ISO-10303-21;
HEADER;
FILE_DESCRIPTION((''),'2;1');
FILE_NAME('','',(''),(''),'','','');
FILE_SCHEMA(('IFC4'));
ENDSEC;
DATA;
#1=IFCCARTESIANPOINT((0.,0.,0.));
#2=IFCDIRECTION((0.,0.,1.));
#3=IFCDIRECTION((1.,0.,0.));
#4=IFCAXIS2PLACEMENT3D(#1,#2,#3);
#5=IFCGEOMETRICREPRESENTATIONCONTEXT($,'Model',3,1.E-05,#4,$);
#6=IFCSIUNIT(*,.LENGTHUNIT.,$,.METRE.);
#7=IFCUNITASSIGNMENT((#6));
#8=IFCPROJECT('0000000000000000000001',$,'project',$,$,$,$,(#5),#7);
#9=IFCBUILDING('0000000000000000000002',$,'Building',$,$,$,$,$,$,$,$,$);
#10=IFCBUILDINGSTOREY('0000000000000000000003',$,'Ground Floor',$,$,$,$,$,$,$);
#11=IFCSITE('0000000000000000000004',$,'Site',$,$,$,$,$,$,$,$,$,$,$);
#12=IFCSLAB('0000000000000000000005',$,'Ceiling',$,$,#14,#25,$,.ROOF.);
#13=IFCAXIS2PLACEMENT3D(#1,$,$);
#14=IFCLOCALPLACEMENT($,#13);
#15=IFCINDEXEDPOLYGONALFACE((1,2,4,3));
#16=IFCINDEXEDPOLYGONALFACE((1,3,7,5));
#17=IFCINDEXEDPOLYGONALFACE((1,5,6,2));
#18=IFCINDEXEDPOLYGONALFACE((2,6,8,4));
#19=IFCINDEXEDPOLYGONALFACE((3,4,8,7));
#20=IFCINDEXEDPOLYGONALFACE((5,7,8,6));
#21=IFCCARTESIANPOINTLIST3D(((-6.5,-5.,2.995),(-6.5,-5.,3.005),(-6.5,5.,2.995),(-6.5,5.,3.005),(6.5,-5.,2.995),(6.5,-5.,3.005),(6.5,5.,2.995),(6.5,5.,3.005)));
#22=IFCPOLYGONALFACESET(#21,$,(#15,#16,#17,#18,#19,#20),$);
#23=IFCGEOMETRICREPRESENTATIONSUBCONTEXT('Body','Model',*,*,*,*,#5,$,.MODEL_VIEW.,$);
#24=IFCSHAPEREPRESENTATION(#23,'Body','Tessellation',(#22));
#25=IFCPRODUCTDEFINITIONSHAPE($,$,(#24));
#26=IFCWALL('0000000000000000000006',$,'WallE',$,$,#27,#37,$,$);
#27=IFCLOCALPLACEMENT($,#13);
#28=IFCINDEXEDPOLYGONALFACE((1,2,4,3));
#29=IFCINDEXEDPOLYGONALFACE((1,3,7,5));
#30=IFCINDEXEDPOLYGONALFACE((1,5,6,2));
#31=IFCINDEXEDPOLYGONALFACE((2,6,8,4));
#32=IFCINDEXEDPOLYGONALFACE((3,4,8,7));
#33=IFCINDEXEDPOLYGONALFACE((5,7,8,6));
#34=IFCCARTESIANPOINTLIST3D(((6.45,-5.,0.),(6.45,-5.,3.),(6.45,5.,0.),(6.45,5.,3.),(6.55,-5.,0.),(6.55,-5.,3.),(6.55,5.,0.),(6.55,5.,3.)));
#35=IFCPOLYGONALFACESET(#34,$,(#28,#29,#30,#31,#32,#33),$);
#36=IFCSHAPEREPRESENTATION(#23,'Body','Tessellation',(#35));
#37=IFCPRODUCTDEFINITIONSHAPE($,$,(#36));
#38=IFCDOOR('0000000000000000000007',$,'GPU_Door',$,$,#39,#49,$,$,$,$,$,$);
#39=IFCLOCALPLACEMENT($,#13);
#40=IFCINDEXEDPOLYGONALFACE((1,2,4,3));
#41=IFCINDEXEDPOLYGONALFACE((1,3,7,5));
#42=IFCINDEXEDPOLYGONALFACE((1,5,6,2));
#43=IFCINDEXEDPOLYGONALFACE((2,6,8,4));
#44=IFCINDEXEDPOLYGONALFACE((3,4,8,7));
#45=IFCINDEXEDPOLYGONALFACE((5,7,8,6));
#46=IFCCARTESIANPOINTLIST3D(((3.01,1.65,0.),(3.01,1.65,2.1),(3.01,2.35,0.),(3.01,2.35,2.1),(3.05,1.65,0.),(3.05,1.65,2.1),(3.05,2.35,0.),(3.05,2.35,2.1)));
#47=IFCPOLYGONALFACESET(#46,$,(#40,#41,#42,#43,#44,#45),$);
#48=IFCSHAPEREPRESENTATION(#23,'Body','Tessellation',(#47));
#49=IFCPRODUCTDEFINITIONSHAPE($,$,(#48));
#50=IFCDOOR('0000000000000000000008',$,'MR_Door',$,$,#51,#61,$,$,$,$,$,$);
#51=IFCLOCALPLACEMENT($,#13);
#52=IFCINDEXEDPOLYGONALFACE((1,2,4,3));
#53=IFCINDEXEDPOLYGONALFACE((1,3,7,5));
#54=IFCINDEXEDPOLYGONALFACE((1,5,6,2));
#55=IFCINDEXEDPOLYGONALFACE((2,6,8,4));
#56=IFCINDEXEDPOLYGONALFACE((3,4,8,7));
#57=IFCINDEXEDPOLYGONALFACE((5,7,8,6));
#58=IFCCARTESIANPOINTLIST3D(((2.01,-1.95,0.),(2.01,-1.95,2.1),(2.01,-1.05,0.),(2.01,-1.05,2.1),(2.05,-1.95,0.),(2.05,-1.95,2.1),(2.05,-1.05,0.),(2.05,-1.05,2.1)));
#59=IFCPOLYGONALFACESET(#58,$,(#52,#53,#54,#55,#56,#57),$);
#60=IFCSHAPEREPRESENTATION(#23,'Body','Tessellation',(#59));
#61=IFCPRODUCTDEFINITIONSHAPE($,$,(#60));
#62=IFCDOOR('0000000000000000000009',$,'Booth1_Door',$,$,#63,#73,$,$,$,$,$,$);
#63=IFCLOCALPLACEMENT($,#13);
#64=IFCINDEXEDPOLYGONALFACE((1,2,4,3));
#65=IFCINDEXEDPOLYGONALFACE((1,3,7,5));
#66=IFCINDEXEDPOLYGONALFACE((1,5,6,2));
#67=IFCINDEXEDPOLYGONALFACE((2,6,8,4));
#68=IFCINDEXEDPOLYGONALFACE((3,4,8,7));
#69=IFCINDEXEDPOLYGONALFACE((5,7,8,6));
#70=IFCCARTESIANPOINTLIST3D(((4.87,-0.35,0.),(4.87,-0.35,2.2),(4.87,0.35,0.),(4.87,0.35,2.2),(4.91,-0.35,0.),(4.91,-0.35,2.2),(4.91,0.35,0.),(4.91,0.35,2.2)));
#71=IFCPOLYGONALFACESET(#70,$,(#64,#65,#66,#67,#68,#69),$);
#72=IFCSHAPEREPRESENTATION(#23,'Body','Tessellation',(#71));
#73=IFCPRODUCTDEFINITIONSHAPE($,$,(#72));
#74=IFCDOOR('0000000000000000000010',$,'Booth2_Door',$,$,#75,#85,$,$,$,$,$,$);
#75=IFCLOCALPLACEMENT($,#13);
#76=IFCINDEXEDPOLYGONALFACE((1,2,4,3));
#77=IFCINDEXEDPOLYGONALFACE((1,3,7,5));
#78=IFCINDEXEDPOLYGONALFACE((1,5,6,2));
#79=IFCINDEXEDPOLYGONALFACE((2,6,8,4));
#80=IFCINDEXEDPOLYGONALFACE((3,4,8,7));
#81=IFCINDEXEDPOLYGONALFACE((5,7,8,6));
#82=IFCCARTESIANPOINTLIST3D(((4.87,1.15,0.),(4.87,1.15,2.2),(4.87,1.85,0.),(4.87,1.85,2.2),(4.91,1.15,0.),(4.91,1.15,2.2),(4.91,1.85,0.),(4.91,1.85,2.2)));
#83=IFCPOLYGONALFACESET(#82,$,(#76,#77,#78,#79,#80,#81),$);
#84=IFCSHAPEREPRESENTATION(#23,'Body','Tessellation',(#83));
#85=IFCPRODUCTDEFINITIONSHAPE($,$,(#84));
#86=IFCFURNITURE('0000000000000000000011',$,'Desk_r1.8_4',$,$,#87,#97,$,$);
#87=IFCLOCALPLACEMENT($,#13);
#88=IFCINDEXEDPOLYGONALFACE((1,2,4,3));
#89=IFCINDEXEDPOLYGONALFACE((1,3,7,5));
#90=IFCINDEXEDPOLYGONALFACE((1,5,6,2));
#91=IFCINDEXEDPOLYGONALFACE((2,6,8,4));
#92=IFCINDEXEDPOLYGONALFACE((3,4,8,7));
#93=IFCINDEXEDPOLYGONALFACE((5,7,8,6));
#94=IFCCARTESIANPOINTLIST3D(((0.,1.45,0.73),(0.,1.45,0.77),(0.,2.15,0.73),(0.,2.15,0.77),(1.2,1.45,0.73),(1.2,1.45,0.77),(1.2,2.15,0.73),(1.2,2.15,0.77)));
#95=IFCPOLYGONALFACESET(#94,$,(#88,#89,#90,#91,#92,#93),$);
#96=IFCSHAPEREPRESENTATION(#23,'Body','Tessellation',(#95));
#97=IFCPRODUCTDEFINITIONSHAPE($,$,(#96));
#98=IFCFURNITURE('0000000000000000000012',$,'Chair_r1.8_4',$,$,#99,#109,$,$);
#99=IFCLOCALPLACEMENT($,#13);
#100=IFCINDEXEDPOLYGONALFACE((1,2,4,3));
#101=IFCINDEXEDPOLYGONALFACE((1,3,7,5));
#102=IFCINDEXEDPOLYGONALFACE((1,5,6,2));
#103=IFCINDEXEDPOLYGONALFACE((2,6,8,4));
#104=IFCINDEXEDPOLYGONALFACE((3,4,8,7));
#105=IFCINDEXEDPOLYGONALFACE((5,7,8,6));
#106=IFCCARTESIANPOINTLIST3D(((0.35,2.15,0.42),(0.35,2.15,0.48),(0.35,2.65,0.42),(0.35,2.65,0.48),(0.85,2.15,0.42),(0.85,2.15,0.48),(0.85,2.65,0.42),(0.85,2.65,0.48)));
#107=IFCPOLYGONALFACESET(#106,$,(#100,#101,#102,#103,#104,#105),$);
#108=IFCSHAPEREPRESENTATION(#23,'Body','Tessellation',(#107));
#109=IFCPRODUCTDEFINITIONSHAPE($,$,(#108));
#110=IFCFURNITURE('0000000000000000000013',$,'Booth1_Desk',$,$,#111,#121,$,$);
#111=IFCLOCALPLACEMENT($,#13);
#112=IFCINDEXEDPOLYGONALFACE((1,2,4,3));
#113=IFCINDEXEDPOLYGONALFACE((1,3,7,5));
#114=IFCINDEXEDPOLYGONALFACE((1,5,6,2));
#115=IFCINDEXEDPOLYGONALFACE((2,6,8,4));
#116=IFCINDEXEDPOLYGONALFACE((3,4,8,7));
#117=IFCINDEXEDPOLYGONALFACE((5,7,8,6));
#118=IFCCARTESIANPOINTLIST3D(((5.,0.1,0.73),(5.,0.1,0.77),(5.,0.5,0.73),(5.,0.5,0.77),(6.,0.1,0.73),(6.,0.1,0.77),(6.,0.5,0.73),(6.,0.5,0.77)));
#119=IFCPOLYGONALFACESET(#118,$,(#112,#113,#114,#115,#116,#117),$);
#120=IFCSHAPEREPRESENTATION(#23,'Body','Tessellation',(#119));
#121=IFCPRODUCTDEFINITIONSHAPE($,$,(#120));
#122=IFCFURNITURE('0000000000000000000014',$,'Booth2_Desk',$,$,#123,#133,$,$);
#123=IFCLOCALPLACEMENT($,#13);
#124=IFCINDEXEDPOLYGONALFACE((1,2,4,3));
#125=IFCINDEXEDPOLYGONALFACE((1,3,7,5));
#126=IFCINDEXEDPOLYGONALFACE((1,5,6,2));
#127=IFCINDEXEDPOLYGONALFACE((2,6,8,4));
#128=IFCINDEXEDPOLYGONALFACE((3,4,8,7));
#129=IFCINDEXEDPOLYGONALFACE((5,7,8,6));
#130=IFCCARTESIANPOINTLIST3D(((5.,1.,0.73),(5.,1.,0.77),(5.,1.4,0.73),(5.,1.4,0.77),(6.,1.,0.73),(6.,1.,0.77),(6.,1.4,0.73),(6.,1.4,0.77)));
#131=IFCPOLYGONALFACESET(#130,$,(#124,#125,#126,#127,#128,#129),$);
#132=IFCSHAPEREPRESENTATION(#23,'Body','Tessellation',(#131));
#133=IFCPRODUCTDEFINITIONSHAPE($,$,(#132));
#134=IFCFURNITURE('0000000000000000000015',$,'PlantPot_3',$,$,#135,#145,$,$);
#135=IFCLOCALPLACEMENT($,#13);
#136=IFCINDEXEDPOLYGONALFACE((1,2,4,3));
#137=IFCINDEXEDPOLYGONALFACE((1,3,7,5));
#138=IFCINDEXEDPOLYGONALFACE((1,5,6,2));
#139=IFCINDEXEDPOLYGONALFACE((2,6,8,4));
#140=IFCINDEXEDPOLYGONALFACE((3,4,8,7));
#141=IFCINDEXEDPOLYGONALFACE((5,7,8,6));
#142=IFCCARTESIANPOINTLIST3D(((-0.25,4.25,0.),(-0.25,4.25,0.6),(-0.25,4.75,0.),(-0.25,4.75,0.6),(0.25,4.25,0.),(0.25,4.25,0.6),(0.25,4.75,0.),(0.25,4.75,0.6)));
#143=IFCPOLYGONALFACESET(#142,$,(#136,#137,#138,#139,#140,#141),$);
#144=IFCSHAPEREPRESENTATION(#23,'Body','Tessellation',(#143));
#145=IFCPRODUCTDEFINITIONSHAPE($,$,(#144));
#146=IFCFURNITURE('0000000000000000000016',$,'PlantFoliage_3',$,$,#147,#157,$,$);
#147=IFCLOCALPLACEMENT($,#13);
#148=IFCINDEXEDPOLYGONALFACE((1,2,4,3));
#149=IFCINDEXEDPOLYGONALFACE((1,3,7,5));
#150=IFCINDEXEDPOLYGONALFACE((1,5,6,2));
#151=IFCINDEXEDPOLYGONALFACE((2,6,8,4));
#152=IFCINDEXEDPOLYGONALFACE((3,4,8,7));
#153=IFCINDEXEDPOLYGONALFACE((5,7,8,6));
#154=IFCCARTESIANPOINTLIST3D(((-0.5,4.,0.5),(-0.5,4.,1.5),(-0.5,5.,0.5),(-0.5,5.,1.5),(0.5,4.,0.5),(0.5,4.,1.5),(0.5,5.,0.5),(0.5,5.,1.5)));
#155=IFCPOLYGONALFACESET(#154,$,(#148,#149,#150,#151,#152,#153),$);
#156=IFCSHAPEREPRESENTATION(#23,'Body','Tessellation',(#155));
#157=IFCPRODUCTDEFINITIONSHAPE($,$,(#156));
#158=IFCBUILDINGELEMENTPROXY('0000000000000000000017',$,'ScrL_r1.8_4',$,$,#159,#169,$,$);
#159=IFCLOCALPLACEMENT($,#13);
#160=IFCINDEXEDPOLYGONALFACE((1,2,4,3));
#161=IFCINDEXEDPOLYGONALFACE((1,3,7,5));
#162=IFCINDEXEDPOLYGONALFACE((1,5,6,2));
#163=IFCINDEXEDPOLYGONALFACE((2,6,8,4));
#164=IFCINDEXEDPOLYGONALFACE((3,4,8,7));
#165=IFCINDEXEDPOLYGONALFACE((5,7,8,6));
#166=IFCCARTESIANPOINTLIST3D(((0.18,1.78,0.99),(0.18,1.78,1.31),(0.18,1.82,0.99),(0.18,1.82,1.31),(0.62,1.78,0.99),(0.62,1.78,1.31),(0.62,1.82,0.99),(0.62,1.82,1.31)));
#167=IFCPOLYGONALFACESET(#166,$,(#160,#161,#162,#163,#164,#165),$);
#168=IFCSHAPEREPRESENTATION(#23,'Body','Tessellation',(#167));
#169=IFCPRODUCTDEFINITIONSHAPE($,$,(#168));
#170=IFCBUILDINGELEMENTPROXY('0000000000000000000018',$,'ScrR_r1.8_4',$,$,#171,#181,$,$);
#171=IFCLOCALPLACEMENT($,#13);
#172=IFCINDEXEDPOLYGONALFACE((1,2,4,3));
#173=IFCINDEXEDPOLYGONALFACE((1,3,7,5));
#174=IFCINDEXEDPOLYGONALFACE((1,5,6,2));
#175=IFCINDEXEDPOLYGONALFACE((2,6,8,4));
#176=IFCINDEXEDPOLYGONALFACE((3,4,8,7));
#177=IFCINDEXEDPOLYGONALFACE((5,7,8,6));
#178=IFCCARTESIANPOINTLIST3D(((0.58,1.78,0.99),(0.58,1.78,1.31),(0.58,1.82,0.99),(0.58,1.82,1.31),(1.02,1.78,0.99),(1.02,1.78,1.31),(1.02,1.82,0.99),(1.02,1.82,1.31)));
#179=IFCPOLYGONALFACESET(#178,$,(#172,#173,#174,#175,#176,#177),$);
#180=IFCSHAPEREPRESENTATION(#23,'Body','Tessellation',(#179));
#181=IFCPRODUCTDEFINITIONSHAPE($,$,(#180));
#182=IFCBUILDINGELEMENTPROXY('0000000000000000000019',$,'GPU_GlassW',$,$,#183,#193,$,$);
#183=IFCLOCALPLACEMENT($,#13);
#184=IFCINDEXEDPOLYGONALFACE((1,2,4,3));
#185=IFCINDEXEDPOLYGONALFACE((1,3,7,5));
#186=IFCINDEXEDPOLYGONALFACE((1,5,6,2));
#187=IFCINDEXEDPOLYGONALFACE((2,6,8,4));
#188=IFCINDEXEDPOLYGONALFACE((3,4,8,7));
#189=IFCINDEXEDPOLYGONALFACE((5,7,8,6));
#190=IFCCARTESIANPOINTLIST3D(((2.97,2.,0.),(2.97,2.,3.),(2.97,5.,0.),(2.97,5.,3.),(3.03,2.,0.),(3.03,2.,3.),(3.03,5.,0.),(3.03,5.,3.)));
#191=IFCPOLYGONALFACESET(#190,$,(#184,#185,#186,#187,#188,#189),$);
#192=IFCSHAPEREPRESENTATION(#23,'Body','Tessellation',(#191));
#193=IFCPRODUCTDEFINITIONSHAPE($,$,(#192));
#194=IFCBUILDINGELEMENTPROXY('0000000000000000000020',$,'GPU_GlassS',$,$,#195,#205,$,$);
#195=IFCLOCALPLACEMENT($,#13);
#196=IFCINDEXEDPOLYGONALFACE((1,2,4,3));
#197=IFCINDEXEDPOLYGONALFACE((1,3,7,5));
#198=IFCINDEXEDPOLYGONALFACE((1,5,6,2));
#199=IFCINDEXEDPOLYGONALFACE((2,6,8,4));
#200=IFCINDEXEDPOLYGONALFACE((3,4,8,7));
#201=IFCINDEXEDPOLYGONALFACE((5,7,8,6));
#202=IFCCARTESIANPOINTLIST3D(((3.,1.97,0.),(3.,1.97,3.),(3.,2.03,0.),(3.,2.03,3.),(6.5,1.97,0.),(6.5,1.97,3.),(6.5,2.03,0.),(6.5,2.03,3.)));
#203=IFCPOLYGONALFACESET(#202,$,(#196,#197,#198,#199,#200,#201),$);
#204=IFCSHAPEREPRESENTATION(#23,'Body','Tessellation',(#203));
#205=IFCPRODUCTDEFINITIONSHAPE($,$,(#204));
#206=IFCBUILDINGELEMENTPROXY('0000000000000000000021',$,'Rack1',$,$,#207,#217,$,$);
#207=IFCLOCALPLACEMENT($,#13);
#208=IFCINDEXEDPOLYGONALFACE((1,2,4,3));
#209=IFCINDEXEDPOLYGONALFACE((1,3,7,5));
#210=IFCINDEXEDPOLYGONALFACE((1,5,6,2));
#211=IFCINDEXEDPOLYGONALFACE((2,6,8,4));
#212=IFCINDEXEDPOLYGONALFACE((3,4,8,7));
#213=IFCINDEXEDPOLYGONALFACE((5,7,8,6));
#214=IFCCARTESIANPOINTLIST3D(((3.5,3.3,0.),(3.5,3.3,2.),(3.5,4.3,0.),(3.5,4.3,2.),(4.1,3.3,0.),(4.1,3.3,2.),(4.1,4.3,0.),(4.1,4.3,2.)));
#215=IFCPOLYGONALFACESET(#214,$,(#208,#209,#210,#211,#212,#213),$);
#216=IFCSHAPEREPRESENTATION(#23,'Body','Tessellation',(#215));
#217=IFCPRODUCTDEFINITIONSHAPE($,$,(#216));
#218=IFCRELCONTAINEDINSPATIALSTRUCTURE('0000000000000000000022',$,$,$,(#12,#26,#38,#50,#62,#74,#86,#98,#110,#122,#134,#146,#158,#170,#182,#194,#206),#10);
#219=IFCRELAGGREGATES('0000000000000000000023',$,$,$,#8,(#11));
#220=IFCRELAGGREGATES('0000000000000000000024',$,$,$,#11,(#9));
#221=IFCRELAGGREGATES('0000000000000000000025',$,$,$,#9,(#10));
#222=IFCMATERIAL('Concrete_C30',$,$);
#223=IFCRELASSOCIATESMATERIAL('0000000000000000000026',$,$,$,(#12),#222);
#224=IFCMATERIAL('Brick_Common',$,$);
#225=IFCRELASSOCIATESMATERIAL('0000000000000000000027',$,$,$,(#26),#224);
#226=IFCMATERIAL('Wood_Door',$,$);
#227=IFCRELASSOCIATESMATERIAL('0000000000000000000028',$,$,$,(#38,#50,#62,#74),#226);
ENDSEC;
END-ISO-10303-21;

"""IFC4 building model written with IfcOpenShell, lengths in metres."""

from ifc_helpers import new_model, si_unit, frame, origin_with_axes, origin_2d, place, context, subcontext, project, spatial, rectangle, extrude, material, element, save


model = new_model("IFC4")

# Units and contexts
model_context = context("Model", 3, precision=1e-05, world=origin_with_axes())
body_context = subcontext(model_context, "Body", "Model", "MODEL_VIEW")
ifc_project = project(units=[si_unit("LENGTHUNIT", "METRE")], contexts=[model_context])

# Site, building, storey
site = spatial("IfcSite", under=ifc_project, Name="Site")
building = spatial("IfcBuilding", under=site, Name="Building")
storey = spatial("IfcBuildingStorey", under=building, Name="Ground Floor")

# Slab
ifc_material_1 = material(Name="Concrete_C30")
slab_placement = place(None, frame((0.0, 0.0, 3.0), z_axis=(0.0, 0.0, 1.0), x_axis=(1.0, 0.0, 0.0)))
element("IfcSlab", 1, at=slab_placement, inside=storey, material=ifc_material_1, Name="Ceiling", PredefinedType="ROOF", context=body_context, shape_type="SweptSolid", body=[
    extrude(rectangle(XDim=13.0, YDim=10.0, at=origin_2d()), frame((0.0, 0.0, -0.005)), (0.0, 0.0, 1.0), 0.01),
])

# Wall
ifc_material_2 = material(Name="Brick_Common")
wall_placement = place(None, frame((6.5, 0.0, 1.5), z_axis=(0.0, 0.0, 1.0), x_axis=(1.0, 0.0, 0.0)))
element("IfcWall", 2, at=wall_placement, inside=storey, material=ifc_material_2, Name="WallE", context=body_context, shape_type="SweptSolid", body=[
    extrude(rectangle(XDim=0.1, YDim=10.0, at=origin_2d()), frame((0.0, 0.0, -1.5)), (0.0, 0.0, 1.0), 3.0),
])

# Doors
ifc_material_3 = material(Name="Wood_Door")
door_1_placement = place(None, frame((3.03, 2.0, 1.05), z_axis=(0.0, 0.0, 1.0), x_axis=(1.0, 0.0, 0.0)))
element("IfcDoor", 3, at=door_1_placement, inside=storey, material=ifc_material_3, Name="GPU_Door", context=body_context, shape_type="SweptSolid", body=[
    extrude(rectangle(XDim=0.04, YDim=0.7, at=origin_2d()), frame((0.0, 0.0, -1.05)), (0.0, 0.0, 1.0), 2.1),
])
door_2_placement = place(None, frame((2.03, -1.5, 1.05), z_axis=(0.0, 0.0, 1.0), x_axis=(1.0, 0.0, 0.0)))
element("IfcDoor", 4, at=door_2_placement, inside=storey, material=ifc_material_3, Name="MR_Door", context=body_context, shape_type="SweptSolid", body=[
    extrude(rectangle(XDim=0.04, YDim=0.9, at=origin_2d()), frame((0.0, 0.0, -1.05)), (0.0, 0.0, 1.0), 2.1),
])
for number, where, z_axis, x_axis, name in (
    (5, (4.89, 0.0, 1.1), (0.0, 0.0, 1.0), (1.0, 0.0, 0.0), "Booth1_Door"),
    (6, (4.89, 1.5, 1.1), (0.0, 0.0, 1.0), (1.0, 0.0, 0.0), "Booth2_Door"),
):
    element("IfcDoor", number, at=place(None, frame(where, z_axis=z_axis, x_axis=x_axis)), inside=storey, material=ifc_material_3, Name=name, context=body_context, shape_type="SweptSolid", body=[
        extrude(rectangle(XDim=0.04, YDim=0.7, at=origin_2d()), frame((0.0, 0.0, -1.1)), (0.0, 0.0, 1.0), 2.2),
    ])

# Furniture
furniture_1_placement = place(None, frame((0.6, 1.8, 0.75), z_axis=(0.0, 0.0, 1.0), x_axis=(1.0, 0.0, 0.0)))
element("IfcFurniture", 7, at=furniture_1_placement, inside=storey, Name="Desk_r1.8_4", context=body_context, shape_type="SweptSolid", body=[
    extrude(rectangle(XDim=1.2, YDim=0.7, at=origin_2d()), frame((0.0, 0.0, -0.02)), (0.0, 0.0, 1.0), 0.04),
])
furniture_2_placement = place(None, frame((0.6, 2.4, 0.45), z_axis=(0.0, 0.0, 1.0), x_axis=(1.0, 0.0, 0.0)))
element("IfcFurniture", 8, at=furniture_2_placement, inside=storey, Name="Chair_r1.8_4", context=body_context, shape_type="SweptSolid", body=[
    extrude(rectangle(XDim=0.5, YDim=0.5, at=origin_2d()), frame((0.0, 0.0, -0.03)), (0.0, 0.0, 1.0), 0.06),
])
for number, where, z_axis, x_axis, name in (
    (9, (5.5, 0.3, 0.75), (0.0, 0.0, 1.0), (1.0, 0.0, 0.0), "Booth1_Desk"),
    (10, (5.5, 1.2, 0.75), (0.0, 0.0, 1.0), (1.0, 0.0, 0.0), "Booth2_Desk"),
):
    element("IfcFurniture", number, at=place(None, frame(where, z_axis=z_axis, x_axis=x_axis)), inside=storey, Name=name, context=body_context, shape_type="SweptSolid", body=[
        extrude(rectangle(XDim=1.0, YDim=0.4, at=origin_2d()), frame((0.0, 0.0, -0.02)), (0.0, 0.0, 1.0), 0.04),
    ])
furniture_3_placement = place(None, frame((0.0, 4.5, 0.3), z_axis=(0.0, 0.0, 1.0), x_axis=(1.0, 0.0, 0.0)))
element("IfcFurniture", 11, at=furniture_3_placement, inside=storey, Name="PlantPot_3", context=body_context, shape_type="SweptSolid", body=[
    extrude(rectangle(XDim=0.5, YDim=0.5, at=origin_2d()), frame((0.0, 0.0, -0.3)), (0.0, 0.0, 1.0), 0.6),
])
furniture_4_placement = place(None, frame((0.0, 4.5, 1.0), z_axis=(0.0, 0.0, 1.0), x_axis=(1.0, 0.0, 0.0)))
element("IfcFurniture", 12, at=furniture_4_placement, inside=storey, Name="PlantFoliage_3", context=body_context, shape_type="SweptSolid", body=[
    extrude(rectangle(XDim=1.0, YDim=1.0, at=origin_2d()), frame((0.0, 0.0, -0.5)), (0.0, 0.0, 1.0), 1.0),
])

# Building element proxies
for number, where, z_axis, x_axis, name in (
    (13, (0.4, 1.8, 1.15), (0.0, 0.0, 1.0), (1.0, 0.0, 0.0), "ScrL_r1.8_4"),
    (14, (0.8, 1.8, 1.15), (0.0, 0.0, 1.0), (1.0, 0.0, 0.0), "ScrR_r1.8_4"),
):
    element("IfcBuildingElementProxy", number, at=place(None, frame(where, z_axis=z_axis, x_axis=x_axis)), inside=storey, Name=name, context=body_context, shape_type="SweptSolid", body=[
        extrude(rectangle(XDim=0.44, YDim=0.04, at=origin_2d()), frame((0.0, 0.0, -0.16)), (0.0, 0.0, 1.0), 0.32),
    ])
proxy_1_placement = place(None, frame((3.0, 3.5, 1.5), z_axis=(0.0, 0.0, 1.0), x_axis=(1.0, 0.0, 0.0)))
element("IfcBuildingElementProxy", 15, at=proxy_1_placement, inside=storey, Name="GPU_GlassW", context=body_context, shape_type="SweptSolid", body=[
    extrude(rectangle(XDim=0.06, YDim=3.0, at=origin_2d()), frame((0.0, 0.0, -1.5)), (0.0, 0.0, 1.0), 3.0),
])
proxy_2_placement = place(None, frame((4.75, 2.0, 1.5), z_axis=(0.0, 0.0, 1.0), x_axis=(1.0, 0.0, 0.0)))
element("IfcBuildingElementProxy", 16, at=proxy_2_placement, inside=storey, Name="GPU_GlassS", context=body_context, shape_type="SweptSolid", body=[
    extrude(rectangle(XDim=3.5, YDim=0.06, at=origin_2d()), frame((0.0, 0.0, -1.5)), (0.0, 0.0, 1.0), 3.0),
])
for number, where, z_axis, x_axis, name in (
    (17, (3.8, 3.8, 1.0), (0.0, 0.0, 1.0), (1.0, 0.0, 0.0), "Rack1"),
):
    element("IfcBuildingElementProxy", number, at=place(None, frame(where, z_axis=z_axis, x_axis=x_axis)), inside=storey, Name=name, context=body_context, shape_type="SweptSolid", body=[
        extrude(rectangle(XDim=0.6, YDim=1.0, at=origin_2d()), frame((0.0, 0.0, -1.0)), (0.0, 0.0, 1.0), 2.0),
    ])

save(model, "model.ifc")
